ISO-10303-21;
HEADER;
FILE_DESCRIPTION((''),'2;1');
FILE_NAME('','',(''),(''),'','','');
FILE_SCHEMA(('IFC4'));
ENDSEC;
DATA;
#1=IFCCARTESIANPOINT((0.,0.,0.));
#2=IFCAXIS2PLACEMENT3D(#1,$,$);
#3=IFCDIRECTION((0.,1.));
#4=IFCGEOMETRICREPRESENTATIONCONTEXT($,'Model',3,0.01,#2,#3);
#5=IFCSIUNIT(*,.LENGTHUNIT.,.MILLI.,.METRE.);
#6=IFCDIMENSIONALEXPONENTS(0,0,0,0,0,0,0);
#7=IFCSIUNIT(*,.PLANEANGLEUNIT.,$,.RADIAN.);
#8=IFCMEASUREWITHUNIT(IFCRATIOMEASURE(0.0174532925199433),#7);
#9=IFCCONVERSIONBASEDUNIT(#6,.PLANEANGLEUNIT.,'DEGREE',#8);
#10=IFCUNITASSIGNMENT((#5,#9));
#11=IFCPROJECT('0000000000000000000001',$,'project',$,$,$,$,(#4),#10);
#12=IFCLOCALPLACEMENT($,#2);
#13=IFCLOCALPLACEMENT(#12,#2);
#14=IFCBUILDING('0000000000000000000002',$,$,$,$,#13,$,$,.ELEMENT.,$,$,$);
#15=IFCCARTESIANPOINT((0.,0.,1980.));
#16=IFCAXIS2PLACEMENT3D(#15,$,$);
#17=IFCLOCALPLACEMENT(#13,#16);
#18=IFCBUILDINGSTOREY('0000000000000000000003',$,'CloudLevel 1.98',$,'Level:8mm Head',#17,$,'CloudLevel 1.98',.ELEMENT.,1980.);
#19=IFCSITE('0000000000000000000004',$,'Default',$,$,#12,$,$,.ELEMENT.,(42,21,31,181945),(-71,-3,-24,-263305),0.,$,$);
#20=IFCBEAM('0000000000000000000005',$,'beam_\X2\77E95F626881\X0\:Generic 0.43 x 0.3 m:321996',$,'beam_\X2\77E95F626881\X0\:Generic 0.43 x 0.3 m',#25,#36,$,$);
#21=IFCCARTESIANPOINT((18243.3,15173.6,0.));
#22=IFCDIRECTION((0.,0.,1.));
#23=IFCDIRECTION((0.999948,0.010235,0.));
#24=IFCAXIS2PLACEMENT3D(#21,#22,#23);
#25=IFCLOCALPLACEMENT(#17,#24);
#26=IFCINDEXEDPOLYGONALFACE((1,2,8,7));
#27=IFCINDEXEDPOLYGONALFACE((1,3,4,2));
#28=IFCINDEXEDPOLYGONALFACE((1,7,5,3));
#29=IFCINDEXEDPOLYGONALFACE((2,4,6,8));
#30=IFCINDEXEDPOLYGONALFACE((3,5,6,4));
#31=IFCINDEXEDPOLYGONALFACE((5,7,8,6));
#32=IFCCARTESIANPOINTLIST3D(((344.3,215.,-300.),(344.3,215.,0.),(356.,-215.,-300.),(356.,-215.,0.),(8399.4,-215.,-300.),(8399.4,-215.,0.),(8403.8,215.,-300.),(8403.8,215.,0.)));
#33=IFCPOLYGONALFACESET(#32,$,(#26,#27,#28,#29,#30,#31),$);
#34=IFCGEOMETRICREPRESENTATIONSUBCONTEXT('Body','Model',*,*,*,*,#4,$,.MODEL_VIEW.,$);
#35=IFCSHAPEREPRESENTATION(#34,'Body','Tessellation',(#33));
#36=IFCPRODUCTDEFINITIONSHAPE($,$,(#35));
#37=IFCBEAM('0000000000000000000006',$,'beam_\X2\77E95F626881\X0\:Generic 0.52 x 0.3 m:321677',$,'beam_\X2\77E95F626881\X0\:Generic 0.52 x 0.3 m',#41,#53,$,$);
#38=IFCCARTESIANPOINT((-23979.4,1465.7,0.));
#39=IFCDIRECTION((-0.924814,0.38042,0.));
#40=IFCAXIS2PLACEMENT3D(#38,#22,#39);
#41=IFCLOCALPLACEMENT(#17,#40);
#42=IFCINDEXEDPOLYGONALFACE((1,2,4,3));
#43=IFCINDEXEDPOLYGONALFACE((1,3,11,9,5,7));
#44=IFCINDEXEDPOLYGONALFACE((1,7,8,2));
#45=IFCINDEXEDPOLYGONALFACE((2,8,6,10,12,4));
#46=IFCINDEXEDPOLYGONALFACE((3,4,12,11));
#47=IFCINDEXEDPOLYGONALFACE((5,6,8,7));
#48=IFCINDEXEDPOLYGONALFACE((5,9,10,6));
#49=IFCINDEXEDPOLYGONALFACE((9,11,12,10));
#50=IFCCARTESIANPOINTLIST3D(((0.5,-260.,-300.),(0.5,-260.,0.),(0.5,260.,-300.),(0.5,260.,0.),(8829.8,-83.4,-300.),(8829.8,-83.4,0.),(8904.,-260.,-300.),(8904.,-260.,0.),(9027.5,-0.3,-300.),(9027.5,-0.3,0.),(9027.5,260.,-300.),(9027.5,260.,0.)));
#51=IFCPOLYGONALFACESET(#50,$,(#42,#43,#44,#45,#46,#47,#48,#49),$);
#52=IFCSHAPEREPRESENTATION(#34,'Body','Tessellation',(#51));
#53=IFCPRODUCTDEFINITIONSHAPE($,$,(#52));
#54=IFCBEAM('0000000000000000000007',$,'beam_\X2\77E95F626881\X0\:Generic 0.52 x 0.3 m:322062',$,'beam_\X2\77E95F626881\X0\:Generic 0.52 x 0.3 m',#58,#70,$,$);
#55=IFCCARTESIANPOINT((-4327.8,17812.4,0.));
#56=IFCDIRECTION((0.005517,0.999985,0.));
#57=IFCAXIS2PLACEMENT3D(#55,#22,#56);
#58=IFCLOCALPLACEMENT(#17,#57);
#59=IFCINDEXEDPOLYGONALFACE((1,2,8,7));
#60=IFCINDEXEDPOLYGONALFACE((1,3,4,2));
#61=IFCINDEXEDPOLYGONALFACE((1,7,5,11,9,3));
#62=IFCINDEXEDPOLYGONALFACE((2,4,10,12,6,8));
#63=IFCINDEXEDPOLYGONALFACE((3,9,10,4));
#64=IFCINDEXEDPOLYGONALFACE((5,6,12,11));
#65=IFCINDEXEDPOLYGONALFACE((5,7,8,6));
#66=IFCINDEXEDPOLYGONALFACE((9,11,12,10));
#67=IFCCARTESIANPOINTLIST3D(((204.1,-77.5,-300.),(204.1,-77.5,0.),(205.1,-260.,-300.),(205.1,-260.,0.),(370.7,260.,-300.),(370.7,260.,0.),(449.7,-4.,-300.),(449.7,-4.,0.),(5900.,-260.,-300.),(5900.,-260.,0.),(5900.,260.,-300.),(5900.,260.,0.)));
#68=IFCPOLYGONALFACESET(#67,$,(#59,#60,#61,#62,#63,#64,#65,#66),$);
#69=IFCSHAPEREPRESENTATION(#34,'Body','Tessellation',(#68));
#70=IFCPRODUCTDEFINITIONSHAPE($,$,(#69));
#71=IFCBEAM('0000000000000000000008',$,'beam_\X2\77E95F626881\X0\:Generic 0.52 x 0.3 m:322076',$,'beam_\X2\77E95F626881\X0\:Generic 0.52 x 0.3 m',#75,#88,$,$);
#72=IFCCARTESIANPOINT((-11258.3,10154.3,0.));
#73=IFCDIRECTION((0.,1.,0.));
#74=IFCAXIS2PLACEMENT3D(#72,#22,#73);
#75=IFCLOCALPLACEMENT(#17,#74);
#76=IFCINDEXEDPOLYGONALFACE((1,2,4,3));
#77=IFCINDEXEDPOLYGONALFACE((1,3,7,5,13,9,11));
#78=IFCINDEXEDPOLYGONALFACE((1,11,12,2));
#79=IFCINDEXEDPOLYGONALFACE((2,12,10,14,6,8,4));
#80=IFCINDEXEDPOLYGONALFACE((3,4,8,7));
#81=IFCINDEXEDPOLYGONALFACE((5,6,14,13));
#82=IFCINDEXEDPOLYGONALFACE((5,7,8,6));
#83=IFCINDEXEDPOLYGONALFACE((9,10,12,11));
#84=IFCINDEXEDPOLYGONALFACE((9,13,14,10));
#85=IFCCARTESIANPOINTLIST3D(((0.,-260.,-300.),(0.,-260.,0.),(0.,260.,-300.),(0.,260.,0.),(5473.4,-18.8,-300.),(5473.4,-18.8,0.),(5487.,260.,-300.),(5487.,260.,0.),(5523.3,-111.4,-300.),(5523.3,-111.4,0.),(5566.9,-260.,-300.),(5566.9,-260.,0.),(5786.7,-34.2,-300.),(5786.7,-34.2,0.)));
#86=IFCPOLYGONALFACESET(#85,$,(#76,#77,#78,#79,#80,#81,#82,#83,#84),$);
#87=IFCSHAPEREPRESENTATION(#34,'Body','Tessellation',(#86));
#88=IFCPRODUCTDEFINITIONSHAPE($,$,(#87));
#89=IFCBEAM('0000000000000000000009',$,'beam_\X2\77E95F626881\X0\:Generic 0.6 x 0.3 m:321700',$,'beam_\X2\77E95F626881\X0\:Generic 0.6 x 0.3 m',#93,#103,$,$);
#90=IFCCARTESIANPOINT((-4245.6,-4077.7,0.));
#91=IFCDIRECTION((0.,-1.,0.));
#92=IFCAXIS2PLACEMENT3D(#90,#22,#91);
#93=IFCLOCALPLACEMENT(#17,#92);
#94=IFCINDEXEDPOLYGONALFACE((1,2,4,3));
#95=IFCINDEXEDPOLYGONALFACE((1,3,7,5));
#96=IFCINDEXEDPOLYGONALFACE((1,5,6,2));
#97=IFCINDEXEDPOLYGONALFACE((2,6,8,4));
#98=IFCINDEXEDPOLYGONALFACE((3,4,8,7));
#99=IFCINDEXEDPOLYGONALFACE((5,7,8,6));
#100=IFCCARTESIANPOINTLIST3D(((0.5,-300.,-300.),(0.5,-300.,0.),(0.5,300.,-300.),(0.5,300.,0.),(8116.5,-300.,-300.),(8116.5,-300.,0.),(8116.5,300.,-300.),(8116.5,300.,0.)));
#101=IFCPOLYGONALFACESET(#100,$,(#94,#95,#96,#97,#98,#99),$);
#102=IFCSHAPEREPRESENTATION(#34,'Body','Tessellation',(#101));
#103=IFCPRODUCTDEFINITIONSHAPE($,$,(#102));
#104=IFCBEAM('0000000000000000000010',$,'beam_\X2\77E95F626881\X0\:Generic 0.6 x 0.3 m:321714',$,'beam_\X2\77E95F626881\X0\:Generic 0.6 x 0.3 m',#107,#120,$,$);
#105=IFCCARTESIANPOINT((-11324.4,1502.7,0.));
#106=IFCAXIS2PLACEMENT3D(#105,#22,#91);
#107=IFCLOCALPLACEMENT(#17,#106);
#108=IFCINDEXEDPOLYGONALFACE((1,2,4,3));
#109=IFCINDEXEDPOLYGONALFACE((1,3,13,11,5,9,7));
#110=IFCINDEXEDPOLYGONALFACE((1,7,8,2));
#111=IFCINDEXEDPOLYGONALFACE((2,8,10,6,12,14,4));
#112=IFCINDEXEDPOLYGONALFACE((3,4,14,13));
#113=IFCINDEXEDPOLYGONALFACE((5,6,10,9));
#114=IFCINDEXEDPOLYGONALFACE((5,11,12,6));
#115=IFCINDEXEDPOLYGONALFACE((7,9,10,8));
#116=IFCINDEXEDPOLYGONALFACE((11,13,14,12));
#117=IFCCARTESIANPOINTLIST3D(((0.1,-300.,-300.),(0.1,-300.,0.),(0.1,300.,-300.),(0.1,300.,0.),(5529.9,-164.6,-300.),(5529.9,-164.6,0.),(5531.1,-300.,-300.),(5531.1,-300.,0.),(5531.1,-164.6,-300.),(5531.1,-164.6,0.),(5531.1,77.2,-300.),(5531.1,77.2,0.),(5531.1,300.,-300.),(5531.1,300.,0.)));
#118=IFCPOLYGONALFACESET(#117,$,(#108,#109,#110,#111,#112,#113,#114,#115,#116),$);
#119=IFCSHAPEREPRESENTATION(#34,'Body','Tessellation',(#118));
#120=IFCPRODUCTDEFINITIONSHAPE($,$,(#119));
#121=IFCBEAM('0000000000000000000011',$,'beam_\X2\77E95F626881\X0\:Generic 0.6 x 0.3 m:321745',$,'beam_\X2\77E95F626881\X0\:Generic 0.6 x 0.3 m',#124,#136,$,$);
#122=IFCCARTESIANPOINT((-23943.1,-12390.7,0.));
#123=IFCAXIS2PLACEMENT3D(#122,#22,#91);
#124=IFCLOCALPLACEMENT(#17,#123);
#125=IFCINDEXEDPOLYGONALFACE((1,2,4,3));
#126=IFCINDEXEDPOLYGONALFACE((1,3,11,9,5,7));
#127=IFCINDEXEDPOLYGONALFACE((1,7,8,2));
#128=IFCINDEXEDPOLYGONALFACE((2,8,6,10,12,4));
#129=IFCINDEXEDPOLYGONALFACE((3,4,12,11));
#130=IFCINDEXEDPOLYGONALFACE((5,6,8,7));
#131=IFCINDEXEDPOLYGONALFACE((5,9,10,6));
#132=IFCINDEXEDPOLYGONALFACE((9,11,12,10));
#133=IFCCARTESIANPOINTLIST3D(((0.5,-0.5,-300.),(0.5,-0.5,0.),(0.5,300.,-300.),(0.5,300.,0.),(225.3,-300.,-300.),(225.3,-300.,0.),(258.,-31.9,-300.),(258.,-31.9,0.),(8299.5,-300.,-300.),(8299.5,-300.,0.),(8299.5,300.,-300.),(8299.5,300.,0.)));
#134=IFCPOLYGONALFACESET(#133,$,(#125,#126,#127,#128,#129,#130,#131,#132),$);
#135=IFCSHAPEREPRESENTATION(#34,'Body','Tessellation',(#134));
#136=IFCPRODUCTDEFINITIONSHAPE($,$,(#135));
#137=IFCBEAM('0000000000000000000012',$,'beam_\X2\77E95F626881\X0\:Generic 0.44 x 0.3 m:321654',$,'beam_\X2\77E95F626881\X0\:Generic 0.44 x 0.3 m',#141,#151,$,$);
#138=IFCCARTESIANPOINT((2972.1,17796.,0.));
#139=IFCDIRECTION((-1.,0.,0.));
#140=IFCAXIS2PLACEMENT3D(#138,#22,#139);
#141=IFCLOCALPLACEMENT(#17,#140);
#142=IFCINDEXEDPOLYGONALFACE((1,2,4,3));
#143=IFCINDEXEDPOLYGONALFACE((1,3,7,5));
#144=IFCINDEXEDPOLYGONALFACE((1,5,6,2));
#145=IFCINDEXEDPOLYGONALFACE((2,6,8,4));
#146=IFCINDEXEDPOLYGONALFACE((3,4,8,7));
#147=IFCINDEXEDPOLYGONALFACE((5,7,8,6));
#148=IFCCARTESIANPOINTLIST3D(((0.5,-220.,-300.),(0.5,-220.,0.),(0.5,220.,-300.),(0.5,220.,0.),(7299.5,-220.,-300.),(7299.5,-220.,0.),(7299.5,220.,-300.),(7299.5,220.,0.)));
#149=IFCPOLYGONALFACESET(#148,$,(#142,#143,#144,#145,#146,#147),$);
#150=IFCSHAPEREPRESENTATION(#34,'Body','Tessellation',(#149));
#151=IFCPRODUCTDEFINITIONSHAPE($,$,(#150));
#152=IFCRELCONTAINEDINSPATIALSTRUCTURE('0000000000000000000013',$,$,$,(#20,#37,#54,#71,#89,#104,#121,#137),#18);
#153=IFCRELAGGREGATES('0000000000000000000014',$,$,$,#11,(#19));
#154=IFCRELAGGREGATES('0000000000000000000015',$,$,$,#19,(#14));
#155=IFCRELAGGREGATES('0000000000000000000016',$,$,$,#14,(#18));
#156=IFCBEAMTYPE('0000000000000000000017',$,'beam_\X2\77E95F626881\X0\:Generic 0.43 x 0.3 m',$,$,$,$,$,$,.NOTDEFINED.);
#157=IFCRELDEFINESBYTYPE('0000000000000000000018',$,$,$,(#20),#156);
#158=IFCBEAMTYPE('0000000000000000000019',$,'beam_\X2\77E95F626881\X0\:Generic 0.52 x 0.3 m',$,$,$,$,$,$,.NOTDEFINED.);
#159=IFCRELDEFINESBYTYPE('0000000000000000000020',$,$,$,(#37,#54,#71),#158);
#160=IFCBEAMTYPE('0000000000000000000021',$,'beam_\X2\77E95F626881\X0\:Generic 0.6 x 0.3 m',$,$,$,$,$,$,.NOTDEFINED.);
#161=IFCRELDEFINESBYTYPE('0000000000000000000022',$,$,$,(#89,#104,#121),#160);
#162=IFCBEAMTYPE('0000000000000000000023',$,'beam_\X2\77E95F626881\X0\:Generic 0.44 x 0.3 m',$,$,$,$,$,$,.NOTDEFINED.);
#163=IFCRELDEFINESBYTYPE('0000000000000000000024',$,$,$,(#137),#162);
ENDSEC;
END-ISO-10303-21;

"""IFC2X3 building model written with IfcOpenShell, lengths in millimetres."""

from ifc_helpers import new_model, entity, si_unit, converted_unit, direction, frame, frame_2d, origin, place, context, subcontext, project, spatial, polyline, rectangle, extrude, clip, halfspace, bounded_halfspace, type_object, element, save


model = new_model("IFC2X3")

# Units and contexts
model_context = context("Model", 3, precision=0.01, world=origin(), true_north=direction((0.0, 1.0)))
body_context = subcontext(model_context, "Body", "Model", "MODEL_VIEW")
ifc_project = project(units=[si_unit("LENGTHUNIT", "METRE", prefix="MILLI"), converted_unit("PLANEANGLEUNIT", "DEGREE", entity("IfcRatioMeasure", 0.0174532925199433), si_unit("PLANEANGLEUNIT", "RADIAN"), dimensions=[0, 0, 0, 0, 0, 0, 0])], contexts=[model_context])

# Site, building, storey
site_placement = place(None, origin())
site = spatial("IfcSite", under=ifc_project, at=site_placement, Name="Default", CompositionType="ELEMENT", RefLatitude=(42, 21, 31, 181945), RefLongitude=(-71, -3, -24, -263305), RefElevation=0.0)
building_placement = place(site_placement, origin())
building = spatial("IfcBuilding", under=site, at=building_placement, CompositionType="ELEMENT")
storey_placement = place(building_placement, frame((0.0, 0.0, 1980.0)))
storey = spatial("IfcBuildingStorey", under=building, at=storey_placement, Name="CloudLevel 1.98", ObjectType="Level:8mm Head", LongName="CloudLevel 1.98", CompositionType="ELEMENT", Elevation=1980.0)

# Beams
beam_type_1 = type_object("IfcBeamType", Name="beam_矩形梁:Generic 0.43 x 0.3 m", PredefinedType="NOTDEFINED")
beam_1_placement = place(storey_placement, frame((18243.3, 15173.6, 0.0), z_axis=(0.0, 0.0, 1.0), x_axis=(0.999948, 0.010235, 0.0)))
element("IfcBeam", 1, at=beam_1_placement, inside=storey, type_object=beam_type_1, Name="beam_矩形梁:Generic 0.43 x 0.3 m:321996", ObjectType="beam_矩形梁:Generic 0.43 x 0.3 m", context=body_context, shape_type="SweptSolid", body=[
    clip(clip(extrude(rectangle(XDim=300.0, YDim=430.0, at=frame_2d((0.0, 0.0), x_axis=(1.0, 0.0))), frame((344.3, 0.0, -150.0), z_axis=(1.0, 0.0, 0.0), x_axis=(0.0, 0.0, -1.0)), (0.0, 0.0, 1.0), 8059.5), halfspace(frame((492.3, -5227.1, -300.0), z_axis=(-0.99963, -0.027195, 0.0), x_axis=(-0.027195, 0.99963, 0.0)), False)), halfspace(frame((8427.1, 2485.6, -300.0), z_axis=(0.999948, -0.010235, 0.0), x_axis=(-0.010235, -0.999948, 0.0)), False)),
])
beam_type_2 = type_object("IfcBeamType", Name="beam_矩形梁:Generic 0.52 x 0.3 m", PredefinedType="NOTDEFINED")
beam_2_placement = place(storey_placement, frame((-23979.4, 1465.7, 0.0), z_axis=(0.0, 0.0, 1.0), x_axis=(-0.924814, 0.38042, 0.0)))
element("IfcBeam", 2, at=beam_2_placement, inside=storey, type_object=beam_type_2, Name="beam_矩形梁:Generic 0.52 x 0.3 m:321677", ObjectType="beam_矩形梁:Generic 0.52 x 0.3 m", context=body_context, shape_type="SweptSolid", body=[
    clip(clip(extrude(rectangle(XDim=300.0, YDim=520.0, at=frame_2d((0.0, 0.0), x_axis=(1.0, 0.0))), frame((0.5, 0.0, -150.0), z_axis=(1.0, 0.0, 0.0), x_axis=(0.0, 0.0, -1.0)), (0.0, 0.0, 1.0), 9027.0), bounded_halfspace(frame((8829.8, -83.4, -300.0), z_axis=(0.921791, 0.387686, 0.0), x_axis=(0.387686, -0.921791, 0.0)), False, frame((0.5, 0.0, -150.0), z_axis=(1.0, 0.0, 0.0), x_axis=(0.0, 0.0, -1.0)), polyline([(150.0, -83.4), (-150.0, -83.4), (-150.0, -260.0), (150.0, -260.0), (150.0, -83.4)]))), bounded_halfspace(frame((9027.9, -0.1, -150.0), z_axis=(0.387686, -0.921791, 0.0), x_axis=(0.0, 0.0, 1.0)), False, frame((0.5, 0.0, -150.0), z_axis=(1.0, 0.0, 0.0), x_axis=(0.0, 0.0, -1.0)), polyline([(-150.0, -83.4), (150.0, -83.4), (150.0, -0.3), (-150.0, -0.3), (-150.0, -83.4)]))),
])
beam_3_placement = place(storey_placement, frame((-4327.8, 17812.4, 0.0), z_axis=(0.0, 0.0, 1.0), x_axis=(0.005517, 0.999985, 0.0)))
element("IfcBeam", 3, at=beam_3_placement, inside=storey, type_object=beam_type_2, Name="beam_矩形梁:Generic 0.52 x 0.3 m:322062", ObjectType="beam_矩形梁:Generic 0.52 x 0.3 m", context=body_context, shape_type="SweptSolid", body=[
    clip(clip(clip(extrude(rectangle(XDim=300.0, YDim=520.0, at=frame_2d((0.0, 0.0), x_axis=(1.0, 0.0))), frame((204.1, 0.0, -150.0), z_axis=(1.0, 0.0, 0.0), x_axis=(0.0, 0.0, -1.0)), (0.0, 0.0, 1.0), 5695.9), halfspace(frame((203.6, 0.7, 0.0), z_axis=(-0.999985, -0.005517, 0.0), x_axis=(0.005517, -0.999985, 0.0)), False)), bounded_halfspace(frame((181.4, -84.3, -150.0), z_axis=(-0.286592, 0.958053, 0.0), x_axis=(0.0, 0.0, 1.0)), False, frame((204.1, 0.0, -150.0), z_axis=(1.0, 0.0, 0.0), x_axis=(0.0, 0.0, -1.0)), polyline([(-150.0, -4.0), (150.0, -4.0), (150.0, -77.5), (-150.0, -77.5), (-150.0, -4.0)]))), bounded_halfspace(frame((449.7, -4.0, -150.0), z_axis=(-0.958053, -0.286592, 0.0), x_axis=(0.0, 0.0, 1.0)), False, frame((204.1, 0.0, -150.0), z_axis=(1.0, 0.0, 0.0), x_axis=(0.0, 0.0, -1.0)), polyline([(150.0, -4.0), (-150.0, -4.0), (-150.0, 260.0), (150.0, 260.0), (150.0, -4.0)]))),
])
beam_4_placement = place(storey_placement, frame((-11258.3, 10154.3, 0.0), z_axis=(0.0, 0.0, 1.0), x_axis=(0.0, 1.0, 0.0)))
element("IfcBeam", 4, at=beam_4_placement, inside=storey, type_object=beam_type_2, Name="beam_矩形梁:Generic 0.52 x 0.3 m:322076", ObjectType="beam_矩形梁:Generic 0.52 x 0.3 m", context=body_context, shape_type="SweptSolid", body=[
    clip(clip(clip(clip(extrude(rectangle(XDim=300.0, YDim=520.0, at=frame_2d((0.0, 0.0), x_axis=(1.0, 0.0))), frame((0.0, 0.0, -150.0), z_axis=(1.0, 0.0, 0.0), x_axis=(0.0, 0.0, -1.0)), (0.0, 0.0, 1.0), 5786.7), bounded_halfspace(frame((5738.1, -31.8, -150.0), z_axis=(0.048929, 0.998802, 0.0), x_axis=(0.0, 0.0, 1.0)), False, frame((0.0, 0.0, -150.0), z_axis=(1.0, 0.0, 0.0), x_axis=(0.0, 0.0, -1.0)), polyline([(150.0, -18.8), (-150.0, -18.8), (-150.0, -34.2), (150.0, -34.2), (150.0, -18.8)]))), bounded_halfspace(frame((5473.4, -18.8, 0.0), z_axis=(0.998802, -0.048929, 0.0), x_axis=(0.048929, 0.998802, 0.0)), False, frame((0.0, 0.0, -150.0), z_axis=(1.0, 0.0, 0.0), x_axis=(0.0, 0.0, -1.0)), polyline([(-150.0, -18.8), (150.0, -18.8), (150.0, 260.0), (-150.0, 260.0), (-150.0, -18.8)]))), bounded_halfspace(frame((7570.3, -7094.5, -150.0), z_axis=(0.959619, 0.281301, 0.0), x_axis=(0.0, 0.0, -1.0)), False, frame((0.0, 0.0, -150.0), z_axis=(1.0, 0.0, 0.0), x_axis=(0.0, 0.0, -1.0)), polyline([(150.0, -111.4), (-150.0, -111.4), (-150.0, -260.0), (150.0, -260.0), (150.0, -111.4)]))), bounded_halfspace(frame((5792.0, -32.6, -150.0), z_axis=(0.281301, -0.959619, 0.0), x_axis=(0.0, 0.0, 1.0)), False, frame((0.0, 0.0, -150.0), z_axis=(1.0, 0.0, 0.0), x_axis=(0.0, 0.0, -1.0)), polyline([(-150.0, -111.4), (150.0, -111.4), (150.0, -34.2), (-150.0, -34.2), (-150.0, -111.4)]))),
])
beam_type_3 = type_object("IfcBeamType", Name="beam_矩形梁:Generic 0.6 x 0.3 m", PredefinedType="NOTDEFINED")
beam_5_placement = place(storey_placement, frame((-4245.6, -4077.7, 0.0), z_axis=(0.0, 0.0, 1.0), x_axis=(0.0, -1.0, 0.0)))
element("IfcBeam", 5, at=beam_5_placement, inside=storey, type_object=beam_type_3, Name="beam_矩形梁:Generic 0.6 x 0.3 m:321700", ObjectType="beam_矩形梁:Generic 0.6 x 0.3 m", context=body_context, shape_type="SweptSolid", body=[
    extrude(rectangle(XDim=300.0, YDim=600.0, at=frame_2d((0.0, 0.0), x_axis=(1.0, 0.0))), frame((0.5, 0.0, -150.0), z_axis=(1.0, 0.0, 0.0), x_axis=(0.0, 0.0, -1.0)), (0.0, 0.0, 1.0), 8116.0),
])
beam_6_placement = place(storey_placement, frame((-11324.4, 1502.7, 0.0), z_axis=(0.0, 0.0, 1.0), x_axis=(0.0, -1.0, 0.0)))
element("IfcBeam", 6, at=beam_6_placement, inside=storey, type_object=beam_type_3, Name="beam_矩形梁:Generic 0.6 x 0.3 m:321714", ObjectType="beam_矩形梁:Generic 0.6 x 0.3 m", context=body_context, shape_type="SweptSolid", body=[
    clip(clip(extrude(rectangle(XDim=300.0, YDim=600.0, at=frame_2d((0.0, 0.0), x_axis=(1.0, 0.0))), frame((0.1, 0.0, -150.0), z_axis=(1.0, 0.0, 0.0), x_axis=(0.0, 0.0, -1.0)), (0.0, 0.0, 1.0), 5531.0), bounded_halfspace(frame((5531.4, 135.4, -150.0), z_axis=(0.999987, -0.005119, 0.0), x_axis=(0.0, 0.0, 1.0)), False, frame((0.1, 0.0, -150.0), z_axis=(1.0, 0.0, 0.0), x_axis=(0.0, 0.0, -1.0)), polyline([(-150.0, -164.6), (150.0, -164.6), (150.0, 77.2), (-150.0, 77.2), (-150.0, -164.6)]))), bounded_halfspace(frame((13769.8, -206.8, 0.0), z_axis=(0.005119, 0.999987, 0.0), x_axis=(-0.999987, 0.005119, 0.0)), False, frame((0.1, 0.0, -150.0), z_axis=(1.0, 0.0, 0.0), x_axis=(0.0, 0.0, -1.0)), polyline([(150.0, -164.6), (-150.0, -164.6), (-150.0, -164.6), (150.0, -164.6), (150.0, -164.6)]))),
])
beam_7_placement = place(storey_placement, frame((-23943.1, -12390.7, 0.0), z_axis=(0.0, 0.0, 1.0), x_axis=(0.0, -1.0, 0.0)))
element("IfcBeam", 7, at=beam_7_placement, inside=storey, type_object=beam_type_3, Name="beam_矩形梁:Generic 0.6 x 0.3 m:321745", ObjectType="beam_矩形梁:Generic 0.6 x 0.3 m", context=body_context, shape_type="SweptSolid", body=[
    clip(clip(extrude(rectangle(XDim=300.0, YDim=600.0, at=frame_2d((0.0, 0.0), x_axis=(1.0, 0.0))), frame((0.5, 0.0, -150.0), z_axis=(1.0, 0.0, 0.0), x_axis=(0.0, 0.0, -1.0)), (0.0, 0.0, 1.0), 8299.0), bounded_halfspace(frame((-0.1, -0.4, -150.0), z_axis=(-0.121219, -0.992626, 0.0), x_axis=(0.0, 0.0, 1.0)), False, frame((0.5, 0.0, -150.0), z_axis=(1.0, 0.0, 0.0), x_axis=(0.0, 0.0, -1.0)), polyline([(150.0, -31.9), (-150.0, -31.9), (-150.0, -0.5), (150.0, -0.5), (150.0, -31.9)]))), bounded_halfspace(frame((-760.9, -8376.0, -300.0), z_axis=(-0.992626, 0.121219, 0.0), x_axis=(0.121219, 0.992626, 0.0)), False, frame((0.5, 0.0, -150.0), z_axis=(1.0, 0.0, 0.0), x_axis=(0.0, 0.0, -1.0)), polyline([(-150.0, -31.9), (150.0, -31.9), (150.0, -300.0), (-150.0, -300.0), (-150.0, -31.9)]))),
])
beam_type_4 = type_object("IfcBeamType", Name="beam_矩形梁:Generic 0.44 x 0.3 m", PredefinedType="NOTDEFINED")
beam_8_placement = place(storey_placement, frame((2972.1, 17796.0, 0.0), z_axis=(0.0, 0.0, 1.0), x_axis=(-1.0, 0.0, 0.0)))
element("IfcBeam", 8, at=beam_8_placement, inside=storey, type_object=beam_type_4, Name="beam_矩形梁:Generic 0.44 x 0.3 m:321654", ObjectType="beam_矩形梁:Generic 0.44 x 0.3 m", context=body_context, shape_type="SweptSolid", body=[
    extrude(rectangle(XDim=300.0, YDim=440.0, at=frame_2d((0.0, 0.0), x_axis=(1.0, 0.0))), frame((0.5, 0.0, -150.0), z_axis=(1.0, 0.0, 0.0), x_axis=(0.0, 0.0, -1.0)), (0.0, 0.0, 1.0), 7299.0),
])

save(model, "model.ifc")
